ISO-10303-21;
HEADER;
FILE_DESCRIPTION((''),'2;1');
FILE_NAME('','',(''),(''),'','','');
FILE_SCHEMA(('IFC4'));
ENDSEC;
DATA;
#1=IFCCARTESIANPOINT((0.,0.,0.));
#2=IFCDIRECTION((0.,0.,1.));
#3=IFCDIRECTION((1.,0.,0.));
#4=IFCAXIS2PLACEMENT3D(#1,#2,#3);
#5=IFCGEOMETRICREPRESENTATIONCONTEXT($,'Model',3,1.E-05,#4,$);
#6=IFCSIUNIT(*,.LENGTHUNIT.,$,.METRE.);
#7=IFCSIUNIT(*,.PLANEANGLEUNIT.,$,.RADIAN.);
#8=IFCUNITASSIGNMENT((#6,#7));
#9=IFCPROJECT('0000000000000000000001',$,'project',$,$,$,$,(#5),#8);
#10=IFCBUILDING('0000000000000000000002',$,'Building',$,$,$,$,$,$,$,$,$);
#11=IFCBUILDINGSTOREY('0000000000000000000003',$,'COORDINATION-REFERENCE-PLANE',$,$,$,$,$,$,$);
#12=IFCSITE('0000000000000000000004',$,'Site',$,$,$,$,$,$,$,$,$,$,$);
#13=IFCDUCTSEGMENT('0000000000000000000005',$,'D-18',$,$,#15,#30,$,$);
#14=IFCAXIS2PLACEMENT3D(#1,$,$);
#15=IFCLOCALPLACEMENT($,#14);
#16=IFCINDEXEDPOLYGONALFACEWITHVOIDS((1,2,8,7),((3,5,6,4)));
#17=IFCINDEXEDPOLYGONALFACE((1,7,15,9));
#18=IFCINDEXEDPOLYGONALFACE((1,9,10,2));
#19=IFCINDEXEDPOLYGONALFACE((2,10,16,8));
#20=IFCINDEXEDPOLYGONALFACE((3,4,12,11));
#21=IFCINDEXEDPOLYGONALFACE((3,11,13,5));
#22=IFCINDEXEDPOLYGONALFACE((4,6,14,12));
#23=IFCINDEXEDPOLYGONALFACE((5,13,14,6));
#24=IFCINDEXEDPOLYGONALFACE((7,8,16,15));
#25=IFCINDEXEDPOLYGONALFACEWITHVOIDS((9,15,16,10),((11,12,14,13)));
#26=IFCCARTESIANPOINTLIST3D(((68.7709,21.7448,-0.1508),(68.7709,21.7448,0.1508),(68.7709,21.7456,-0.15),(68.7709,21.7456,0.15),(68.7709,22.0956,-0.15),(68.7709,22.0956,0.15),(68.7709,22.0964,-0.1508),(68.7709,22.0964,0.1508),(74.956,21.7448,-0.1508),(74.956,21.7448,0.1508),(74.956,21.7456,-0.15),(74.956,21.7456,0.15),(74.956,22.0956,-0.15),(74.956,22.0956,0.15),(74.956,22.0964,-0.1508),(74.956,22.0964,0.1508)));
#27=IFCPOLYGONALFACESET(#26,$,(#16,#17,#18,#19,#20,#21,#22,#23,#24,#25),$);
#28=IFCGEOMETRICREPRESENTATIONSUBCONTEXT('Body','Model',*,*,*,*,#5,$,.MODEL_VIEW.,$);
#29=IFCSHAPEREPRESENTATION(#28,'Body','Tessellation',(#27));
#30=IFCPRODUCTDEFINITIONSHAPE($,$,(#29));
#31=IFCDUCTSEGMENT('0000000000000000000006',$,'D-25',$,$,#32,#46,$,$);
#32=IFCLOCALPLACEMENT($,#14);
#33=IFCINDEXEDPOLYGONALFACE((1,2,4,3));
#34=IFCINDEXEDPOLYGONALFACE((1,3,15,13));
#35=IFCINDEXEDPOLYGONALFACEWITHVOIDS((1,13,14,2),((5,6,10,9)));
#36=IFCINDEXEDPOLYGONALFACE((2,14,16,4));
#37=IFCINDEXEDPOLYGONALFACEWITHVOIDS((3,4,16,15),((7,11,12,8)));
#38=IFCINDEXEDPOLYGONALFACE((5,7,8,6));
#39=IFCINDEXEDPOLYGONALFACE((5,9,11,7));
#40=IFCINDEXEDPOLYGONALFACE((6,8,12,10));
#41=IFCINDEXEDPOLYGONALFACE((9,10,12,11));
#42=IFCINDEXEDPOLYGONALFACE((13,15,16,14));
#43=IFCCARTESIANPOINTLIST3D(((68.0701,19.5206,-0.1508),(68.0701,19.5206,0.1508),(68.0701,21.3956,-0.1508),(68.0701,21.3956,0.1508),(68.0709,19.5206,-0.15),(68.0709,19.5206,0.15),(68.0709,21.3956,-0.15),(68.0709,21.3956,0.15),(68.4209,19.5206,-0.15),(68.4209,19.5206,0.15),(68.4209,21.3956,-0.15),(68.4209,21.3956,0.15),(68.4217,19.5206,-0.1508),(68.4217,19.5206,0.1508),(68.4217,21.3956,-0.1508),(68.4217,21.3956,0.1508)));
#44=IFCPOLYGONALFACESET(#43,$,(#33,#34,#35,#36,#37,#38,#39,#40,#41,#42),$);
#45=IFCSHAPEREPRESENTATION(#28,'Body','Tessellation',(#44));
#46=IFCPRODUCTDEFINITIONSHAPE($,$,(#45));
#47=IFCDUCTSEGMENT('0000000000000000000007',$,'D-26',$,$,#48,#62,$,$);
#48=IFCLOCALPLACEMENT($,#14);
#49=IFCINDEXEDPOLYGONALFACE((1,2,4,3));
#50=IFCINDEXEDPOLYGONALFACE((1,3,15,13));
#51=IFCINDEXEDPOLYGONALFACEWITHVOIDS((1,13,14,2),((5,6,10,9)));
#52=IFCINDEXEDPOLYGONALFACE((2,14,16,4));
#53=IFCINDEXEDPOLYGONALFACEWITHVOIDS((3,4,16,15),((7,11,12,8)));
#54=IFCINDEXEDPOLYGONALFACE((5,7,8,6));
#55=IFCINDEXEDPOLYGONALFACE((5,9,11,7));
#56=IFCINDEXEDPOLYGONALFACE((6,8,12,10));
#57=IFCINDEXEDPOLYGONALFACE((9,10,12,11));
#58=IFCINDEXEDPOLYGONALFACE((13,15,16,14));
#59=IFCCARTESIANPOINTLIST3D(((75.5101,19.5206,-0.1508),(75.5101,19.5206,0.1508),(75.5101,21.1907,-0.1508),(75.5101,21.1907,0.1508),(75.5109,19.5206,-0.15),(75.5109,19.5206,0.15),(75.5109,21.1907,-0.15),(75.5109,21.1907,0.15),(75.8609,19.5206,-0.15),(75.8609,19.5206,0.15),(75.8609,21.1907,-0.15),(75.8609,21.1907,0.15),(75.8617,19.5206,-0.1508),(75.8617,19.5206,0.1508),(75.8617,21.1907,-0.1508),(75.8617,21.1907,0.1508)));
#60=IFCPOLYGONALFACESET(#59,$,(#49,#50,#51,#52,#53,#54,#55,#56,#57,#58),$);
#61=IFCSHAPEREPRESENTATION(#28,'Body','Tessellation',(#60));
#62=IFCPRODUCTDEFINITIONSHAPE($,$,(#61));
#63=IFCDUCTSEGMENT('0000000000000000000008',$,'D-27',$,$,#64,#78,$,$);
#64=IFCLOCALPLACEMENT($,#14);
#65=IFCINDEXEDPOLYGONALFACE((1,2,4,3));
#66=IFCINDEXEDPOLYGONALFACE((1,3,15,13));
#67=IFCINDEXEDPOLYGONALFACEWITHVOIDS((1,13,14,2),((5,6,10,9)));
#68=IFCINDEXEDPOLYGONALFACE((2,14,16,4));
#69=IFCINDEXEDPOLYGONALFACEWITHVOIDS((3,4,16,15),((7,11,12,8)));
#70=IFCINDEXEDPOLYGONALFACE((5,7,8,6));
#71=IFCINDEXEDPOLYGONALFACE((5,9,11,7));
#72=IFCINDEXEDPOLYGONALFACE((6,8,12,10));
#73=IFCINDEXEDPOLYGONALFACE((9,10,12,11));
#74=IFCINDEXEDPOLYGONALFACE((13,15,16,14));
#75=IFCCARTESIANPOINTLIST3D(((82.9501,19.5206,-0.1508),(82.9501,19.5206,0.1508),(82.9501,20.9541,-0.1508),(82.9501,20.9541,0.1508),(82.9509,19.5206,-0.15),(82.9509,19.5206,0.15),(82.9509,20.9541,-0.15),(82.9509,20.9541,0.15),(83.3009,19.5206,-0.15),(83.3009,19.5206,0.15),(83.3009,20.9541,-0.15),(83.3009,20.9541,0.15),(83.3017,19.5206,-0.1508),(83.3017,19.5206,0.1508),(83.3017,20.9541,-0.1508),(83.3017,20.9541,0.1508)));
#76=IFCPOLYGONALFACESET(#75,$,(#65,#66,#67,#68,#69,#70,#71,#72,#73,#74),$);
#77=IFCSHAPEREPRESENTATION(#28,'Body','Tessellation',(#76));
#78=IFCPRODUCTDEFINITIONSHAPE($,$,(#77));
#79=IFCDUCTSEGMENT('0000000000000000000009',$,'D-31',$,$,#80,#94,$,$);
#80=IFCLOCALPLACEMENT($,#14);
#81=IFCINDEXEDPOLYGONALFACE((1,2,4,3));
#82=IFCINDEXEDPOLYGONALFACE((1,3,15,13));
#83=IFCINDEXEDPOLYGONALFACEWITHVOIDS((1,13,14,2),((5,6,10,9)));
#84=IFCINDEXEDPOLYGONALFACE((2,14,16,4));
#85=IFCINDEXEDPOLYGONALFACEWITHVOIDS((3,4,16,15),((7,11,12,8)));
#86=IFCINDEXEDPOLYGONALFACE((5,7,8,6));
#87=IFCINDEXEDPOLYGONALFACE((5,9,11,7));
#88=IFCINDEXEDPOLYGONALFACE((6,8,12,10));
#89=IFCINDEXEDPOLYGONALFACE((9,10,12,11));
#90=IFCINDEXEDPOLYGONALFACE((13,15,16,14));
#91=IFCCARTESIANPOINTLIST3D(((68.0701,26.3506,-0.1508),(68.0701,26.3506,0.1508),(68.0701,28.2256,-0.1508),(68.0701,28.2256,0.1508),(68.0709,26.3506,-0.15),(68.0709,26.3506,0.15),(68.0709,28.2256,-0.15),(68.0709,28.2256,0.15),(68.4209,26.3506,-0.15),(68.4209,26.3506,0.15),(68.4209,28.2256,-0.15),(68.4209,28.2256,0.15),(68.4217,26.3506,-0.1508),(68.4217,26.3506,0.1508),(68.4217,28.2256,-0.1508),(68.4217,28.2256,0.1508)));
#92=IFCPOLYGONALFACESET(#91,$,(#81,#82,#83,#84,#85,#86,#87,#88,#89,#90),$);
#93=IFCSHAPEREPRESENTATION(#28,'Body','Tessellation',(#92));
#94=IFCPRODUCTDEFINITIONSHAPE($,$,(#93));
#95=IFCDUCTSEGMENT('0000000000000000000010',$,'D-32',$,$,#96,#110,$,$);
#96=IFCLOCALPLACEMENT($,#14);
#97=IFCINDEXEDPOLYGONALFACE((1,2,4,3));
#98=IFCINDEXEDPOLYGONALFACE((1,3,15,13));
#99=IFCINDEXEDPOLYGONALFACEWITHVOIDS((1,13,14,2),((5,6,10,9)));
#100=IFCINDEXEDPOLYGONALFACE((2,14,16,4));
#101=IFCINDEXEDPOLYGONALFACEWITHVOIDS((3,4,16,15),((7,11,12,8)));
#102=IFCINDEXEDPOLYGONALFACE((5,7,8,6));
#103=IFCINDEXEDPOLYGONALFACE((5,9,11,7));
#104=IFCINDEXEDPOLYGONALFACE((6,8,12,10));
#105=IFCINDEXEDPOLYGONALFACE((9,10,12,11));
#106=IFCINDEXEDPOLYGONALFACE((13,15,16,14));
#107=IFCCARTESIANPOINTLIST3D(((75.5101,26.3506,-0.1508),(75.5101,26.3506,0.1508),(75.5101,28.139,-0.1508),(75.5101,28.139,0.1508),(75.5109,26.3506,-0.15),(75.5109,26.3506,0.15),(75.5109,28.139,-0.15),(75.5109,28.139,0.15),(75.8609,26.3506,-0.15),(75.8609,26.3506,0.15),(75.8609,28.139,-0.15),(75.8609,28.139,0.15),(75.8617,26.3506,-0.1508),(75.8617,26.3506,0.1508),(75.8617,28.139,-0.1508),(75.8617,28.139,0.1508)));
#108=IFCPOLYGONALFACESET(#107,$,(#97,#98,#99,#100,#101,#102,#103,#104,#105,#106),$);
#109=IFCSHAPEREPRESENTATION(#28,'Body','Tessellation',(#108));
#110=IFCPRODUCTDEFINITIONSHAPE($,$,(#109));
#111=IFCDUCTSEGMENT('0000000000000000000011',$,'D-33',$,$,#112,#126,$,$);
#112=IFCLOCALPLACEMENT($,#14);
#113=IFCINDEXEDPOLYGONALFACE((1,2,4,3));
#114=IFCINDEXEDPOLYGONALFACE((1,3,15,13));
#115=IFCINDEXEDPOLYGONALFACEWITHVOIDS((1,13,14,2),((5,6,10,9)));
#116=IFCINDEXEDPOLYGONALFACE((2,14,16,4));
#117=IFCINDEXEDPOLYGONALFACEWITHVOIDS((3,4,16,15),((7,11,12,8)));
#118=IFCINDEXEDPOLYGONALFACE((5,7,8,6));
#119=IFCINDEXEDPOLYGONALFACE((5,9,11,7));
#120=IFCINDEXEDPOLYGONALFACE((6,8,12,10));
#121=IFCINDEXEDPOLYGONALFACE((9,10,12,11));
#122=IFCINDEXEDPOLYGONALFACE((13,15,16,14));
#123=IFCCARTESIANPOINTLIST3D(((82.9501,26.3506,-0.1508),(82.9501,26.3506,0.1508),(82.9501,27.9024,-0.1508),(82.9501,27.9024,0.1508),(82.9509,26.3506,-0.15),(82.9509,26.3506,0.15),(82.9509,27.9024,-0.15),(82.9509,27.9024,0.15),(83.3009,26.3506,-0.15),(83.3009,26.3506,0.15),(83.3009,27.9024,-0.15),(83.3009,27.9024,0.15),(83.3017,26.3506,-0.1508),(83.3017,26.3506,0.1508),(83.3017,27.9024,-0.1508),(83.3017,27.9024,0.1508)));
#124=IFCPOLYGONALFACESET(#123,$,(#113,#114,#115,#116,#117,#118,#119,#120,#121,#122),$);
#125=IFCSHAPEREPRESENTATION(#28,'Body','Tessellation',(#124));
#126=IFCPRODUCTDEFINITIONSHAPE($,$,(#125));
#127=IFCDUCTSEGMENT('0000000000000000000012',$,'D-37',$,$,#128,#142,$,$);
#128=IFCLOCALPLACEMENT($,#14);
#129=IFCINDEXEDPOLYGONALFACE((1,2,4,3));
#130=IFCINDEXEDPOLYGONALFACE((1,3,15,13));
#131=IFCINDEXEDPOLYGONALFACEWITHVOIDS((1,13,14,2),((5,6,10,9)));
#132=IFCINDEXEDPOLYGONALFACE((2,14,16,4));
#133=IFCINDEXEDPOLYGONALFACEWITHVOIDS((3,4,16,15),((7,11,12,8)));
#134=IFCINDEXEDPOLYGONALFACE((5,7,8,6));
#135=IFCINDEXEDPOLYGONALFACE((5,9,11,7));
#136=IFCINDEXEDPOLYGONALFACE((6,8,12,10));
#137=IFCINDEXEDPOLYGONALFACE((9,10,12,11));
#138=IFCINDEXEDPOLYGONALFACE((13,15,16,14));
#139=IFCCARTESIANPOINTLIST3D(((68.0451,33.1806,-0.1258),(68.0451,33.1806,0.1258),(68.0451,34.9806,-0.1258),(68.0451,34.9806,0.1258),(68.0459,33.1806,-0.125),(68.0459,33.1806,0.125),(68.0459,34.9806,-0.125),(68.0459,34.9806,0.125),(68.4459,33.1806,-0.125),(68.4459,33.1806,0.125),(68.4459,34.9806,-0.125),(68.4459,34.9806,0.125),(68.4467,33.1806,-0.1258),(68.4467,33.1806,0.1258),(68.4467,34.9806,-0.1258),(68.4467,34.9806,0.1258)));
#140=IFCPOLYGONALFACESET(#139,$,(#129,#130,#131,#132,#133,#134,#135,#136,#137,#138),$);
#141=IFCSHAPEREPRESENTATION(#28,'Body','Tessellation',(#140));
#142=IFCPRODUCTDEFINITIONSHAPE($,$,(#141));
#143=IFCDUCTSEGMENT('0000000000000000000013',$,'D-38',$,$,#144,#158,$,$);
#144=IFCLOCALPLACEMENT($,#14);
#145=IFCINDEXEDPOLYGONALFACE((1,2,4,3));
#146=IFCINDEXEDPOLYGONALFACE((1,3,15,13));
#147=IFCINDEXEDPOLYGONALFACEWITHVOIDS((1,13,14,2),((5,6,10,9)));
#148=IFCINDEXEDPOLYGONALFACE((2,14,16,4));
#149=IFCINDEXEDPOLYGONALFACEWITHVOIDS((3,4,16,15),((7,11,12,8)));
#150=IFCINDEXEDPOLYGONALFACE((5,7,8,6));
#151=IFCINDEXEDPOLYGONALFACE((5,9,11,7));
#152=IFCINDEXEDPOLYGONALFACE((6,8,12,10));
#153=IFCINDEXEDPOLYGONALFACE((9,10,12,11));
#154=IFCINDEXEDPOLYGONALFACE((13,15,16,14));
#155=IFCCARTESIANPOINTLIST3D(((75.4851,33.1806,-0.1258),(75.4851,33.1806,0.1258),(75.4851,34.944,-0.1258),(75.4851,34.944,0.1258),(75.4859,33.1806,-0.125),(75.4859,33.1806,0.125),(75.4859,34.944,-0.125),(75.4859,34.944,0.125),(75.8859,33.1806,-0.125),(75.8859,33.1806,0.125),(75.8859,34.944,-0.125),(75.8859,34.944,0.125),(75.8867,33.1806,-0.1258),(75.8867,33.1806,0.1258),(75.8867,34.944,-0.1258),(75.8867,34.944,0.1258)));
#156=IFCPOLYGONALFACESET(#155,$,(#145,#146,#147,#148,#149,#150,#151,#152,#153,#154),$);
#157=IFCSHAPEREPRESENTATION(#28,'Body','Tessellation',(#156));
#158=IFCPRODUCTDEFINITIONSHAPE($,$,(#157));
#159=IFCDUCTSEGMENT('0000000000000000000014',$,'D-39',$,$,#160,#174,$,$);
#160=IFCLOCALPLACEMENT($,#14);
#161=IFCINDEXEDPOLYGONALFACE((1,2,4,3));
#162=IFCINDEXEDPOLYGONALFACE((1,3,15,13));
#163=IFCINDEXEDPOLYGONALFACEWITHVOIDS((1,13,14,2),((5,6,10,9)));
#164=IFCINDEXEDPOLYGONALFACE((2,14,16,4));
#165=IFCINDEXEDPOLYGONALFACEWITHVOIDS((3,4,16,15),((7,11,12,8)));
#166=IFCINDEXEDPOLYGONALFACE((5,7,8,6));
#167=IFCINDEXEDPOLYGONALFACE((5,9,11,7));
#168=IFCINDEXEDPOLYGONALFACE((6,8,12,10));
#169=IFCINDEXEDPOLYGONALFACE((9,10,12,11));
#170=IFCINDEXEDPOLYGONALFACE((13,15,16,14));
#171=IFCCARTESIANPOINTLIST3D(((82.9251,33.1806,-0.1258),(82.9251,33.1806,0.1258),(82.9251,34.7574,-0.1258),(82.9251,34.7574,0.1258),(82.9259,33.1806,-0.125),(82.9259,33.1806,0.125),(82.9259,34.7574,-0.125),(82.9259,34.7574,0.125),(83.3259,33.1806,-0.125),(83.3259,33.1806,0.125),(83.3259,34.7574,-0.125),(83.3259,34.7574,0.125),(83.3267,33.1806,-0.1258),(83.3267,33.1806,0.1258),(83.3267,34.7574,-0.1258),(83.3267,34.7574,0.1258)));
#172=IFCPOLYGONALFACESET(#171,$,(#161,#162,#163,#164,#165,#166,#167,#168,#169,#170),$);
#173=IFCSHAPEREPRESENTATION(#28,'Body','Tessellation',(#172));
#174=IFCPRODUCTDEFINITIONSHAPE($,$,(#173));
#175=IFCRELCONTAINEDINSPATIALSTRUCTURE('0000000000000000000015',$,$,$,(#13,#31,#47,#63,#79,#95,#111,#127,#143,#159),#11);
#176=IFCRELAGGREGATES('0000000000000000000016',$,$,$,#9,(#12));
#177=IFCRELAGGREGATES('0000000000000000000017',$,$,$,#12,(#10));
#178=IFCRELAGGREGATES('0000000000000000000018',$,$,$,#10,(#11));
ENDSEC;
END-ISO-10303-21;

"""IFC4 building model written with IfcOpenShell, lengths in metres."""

from ifc_helpers import new_model, si_unit, frame, origin, origin_with_axes, place, context, subcontext, project, spatial, hollow_rectangle, extrude, element, save


model = new_model("IFC4")

# Units and contexts
model_context = context("Model", 3, precision=1e-05, world=origin_with_axes())
body_context = subcontext(model_context, "Body", "Model", "MODEL_VIEW")
ifc_project = project(units=[si_unit("LENGTHUNIT", "METRE"), si_unit("PLANEANGLEUNIT", "RADIAN")], contexts=[model_context])

# Site, building, storey
site = spatial("IfcSite", under=ifc_project, Name="Site")
building = spatial("IfcBuilding", under=site, Name="Building")
storey = spatial("IfcBuildingStorey", under=building, Name="COORDINATION-REFERENCE-PLANE")

# Duct segments
duct_segment_1_placement = place(None, frame((68.7709, 21.9206, 0.0), z_axis=(1.0, 0.0, 0.0), x_axis=(0.0, 1.0, 0.0)))
element("IfcDuctSegment", 1, at=duct_segment_1_placement, inside=storey, Name="D-18", context=body_context, shape_type="SweptSolid", body=[
    extrude(hollow_rectangle(XDim=0.3516, YDim=0.3016, WallThickness=0.0008), origin(), (0.0, 0.0, 1.0), 6.1851),
])
duct_segment_2_placement = place(None, frame((68.2459, 19.5206, 0.0), z_axis=(0.0, 1.0, 0.0), x_axis=(1.0, 0.0, 0.0)))
element("IfcDuctSegment", 2, at=duct_segment_2_placement, inside=storey, Name="D-25", context=body_context, shape_type="SweptSolid", body=[
    extrude(hollow_rectangle(XDim=0.3516, YDim=0.3016, WallThickness=0.0008), origin(), (0.0, 0.0, 1.0), 1.875),
])
duct_segment_3_placement = place(None, frame((75.6859, 19.5206, 0.0), z_axis=(0.0, 1.0, 0.0), x_axis=(1.0, 0.0, 0.0)))
element("IfcDuctSegment", 3, at=duct_segment_3_placement, inside=storey, Name="D-26", context=body_context, shape_type="SweptSolid", body=[
    extrude(hollow_rectangle(XDim=0.3516, YDim=0.3016, WallThickness=0.0008), origin(), (0.0, 0.0, 1.0), 1.6701),
])
duct_segment_4_placement = place(None, frame((83.1259, 19.5206, 0.0), z_axis=(0.0, 1.0, 0.0), x_axis=(1.0, 0.0, 0.0)))
element("IfcDuctSegment", 4, at=duct_segment_4_placement, inside=storey, Name="D-27", context=body_context, shape_type="SweptSolid", body=[
    extrude(hollow_rectangle(XDim=0.3516, YDim=0.3016, WallThickness=0.0008), origin(), (0.0, 0.0, 1.0), 1.4335),
])
duct_segment_5_placement = place(None, frame((68.2459, 26.3506, 0.0), z_axis=(0.0, 1.0, 0.0), x_axis=(1.0, 0.0, 0.0)))
element("IfcDuctSegment", 5, at=duct_segment_5_placement, inside=storey, Name="D-31", context=body_context, shape_type="SweptSolid", body=[
    extrude(hollow_rectangle(XDim=0.3516, YDim=0.3016, WallThickness=0.0008), origin(), (0.0, 0.0, 1.0), 1.875),
])
duct_segment_6_placement = place(None, frame((75.6859, 26.3506, 0.0), z_axis=(0.0, 1.0, 0.0), x_axis=(1.0, 0.0, 0.0)))
element("IfcDuctSegment", 6, at=duct_segment_6_placement, inside=storey, Name="D-32", context=body_context, shape_type="SweptSolid", body=[
    extrude(hollow_rectangle(XDim=0.3516, YDim=0.3016, WallThickness=0.0008), origin(), (0.0, 0.0, 1.0), 1.7884),
])
duct_segment_7_placement = place(None, frame((83.1259, 26.3506, 0.0), z_axis=(0.0, 1.0, 0.0), x_axis=(1.0, 0.0, 0.0)))
element("IfcDuctSegment", 7, at=duct_segment_7_placement, inside=storey, Name="D-33", context=body_context, shape_type="SweptSolid", body=[
    extrude(hollow_rectangle(XDim=0.3516, YDim=0.3016, WallThickness=0.0008), origin(), (0.0, 0.0, 1.0), 1.5518),
])
duct_segment_8_placement = place(None, frame((68.2459, 33.1806, 0.0), z_axis=(0.0, 1.0, 0.0), x_axis=(1.0, 0.0, 0.0)))
element("IfcDuctSegment", 8, at=duct_segment_8_placement, inside=storey, Name="D-37", context=body_context, shape_type="SweptSolid", body=[
    extrude(hollow_rectangle(XDim=0.4016, YDim=0.2516, WallThickness=0.0008), origin(), (0.0, 0.0, 1.0), 1.8),
])
duct_segment_9_placement = place(None, frame((75.6859, 33.1806, 0.0), z_axis=(0.0, 1.0, 0.0), x_axis=(1.0, 0.0, 0.0)))
element("IfcDuctSegment", 9, at=duct_segment_9_placement, inside=storey, Name="D-38", context=body_context, shape_type="SweptSolid", body=[
    extrude(hollow_rectangle(XDim=0.4016, YDim=0.2516, WallThickness=0.0008), origin(), (0.0, 0.0, 1.0), 1.7634),
])
duct_segment_10_placement = place(None, frame((83.1259, 33.1806, 0.0), z_axis=(0.0, 1.0, 0.0), x_axis=(1.0, 0.0, 0.0)))
element("IfcDuctSegment", 10, at=duct_segment_10_placement, inside=storey, Name="D-39", context=body_context, shape_type="SweptSolid", body=[
    extrude(hollow_rectangle(XDim=0.4016, YDim=0.2516, WallThickness=0.0008), origin(), (0.0, 0.0, 1.0), 1.5768),
])

save(model, "model.ifc")
